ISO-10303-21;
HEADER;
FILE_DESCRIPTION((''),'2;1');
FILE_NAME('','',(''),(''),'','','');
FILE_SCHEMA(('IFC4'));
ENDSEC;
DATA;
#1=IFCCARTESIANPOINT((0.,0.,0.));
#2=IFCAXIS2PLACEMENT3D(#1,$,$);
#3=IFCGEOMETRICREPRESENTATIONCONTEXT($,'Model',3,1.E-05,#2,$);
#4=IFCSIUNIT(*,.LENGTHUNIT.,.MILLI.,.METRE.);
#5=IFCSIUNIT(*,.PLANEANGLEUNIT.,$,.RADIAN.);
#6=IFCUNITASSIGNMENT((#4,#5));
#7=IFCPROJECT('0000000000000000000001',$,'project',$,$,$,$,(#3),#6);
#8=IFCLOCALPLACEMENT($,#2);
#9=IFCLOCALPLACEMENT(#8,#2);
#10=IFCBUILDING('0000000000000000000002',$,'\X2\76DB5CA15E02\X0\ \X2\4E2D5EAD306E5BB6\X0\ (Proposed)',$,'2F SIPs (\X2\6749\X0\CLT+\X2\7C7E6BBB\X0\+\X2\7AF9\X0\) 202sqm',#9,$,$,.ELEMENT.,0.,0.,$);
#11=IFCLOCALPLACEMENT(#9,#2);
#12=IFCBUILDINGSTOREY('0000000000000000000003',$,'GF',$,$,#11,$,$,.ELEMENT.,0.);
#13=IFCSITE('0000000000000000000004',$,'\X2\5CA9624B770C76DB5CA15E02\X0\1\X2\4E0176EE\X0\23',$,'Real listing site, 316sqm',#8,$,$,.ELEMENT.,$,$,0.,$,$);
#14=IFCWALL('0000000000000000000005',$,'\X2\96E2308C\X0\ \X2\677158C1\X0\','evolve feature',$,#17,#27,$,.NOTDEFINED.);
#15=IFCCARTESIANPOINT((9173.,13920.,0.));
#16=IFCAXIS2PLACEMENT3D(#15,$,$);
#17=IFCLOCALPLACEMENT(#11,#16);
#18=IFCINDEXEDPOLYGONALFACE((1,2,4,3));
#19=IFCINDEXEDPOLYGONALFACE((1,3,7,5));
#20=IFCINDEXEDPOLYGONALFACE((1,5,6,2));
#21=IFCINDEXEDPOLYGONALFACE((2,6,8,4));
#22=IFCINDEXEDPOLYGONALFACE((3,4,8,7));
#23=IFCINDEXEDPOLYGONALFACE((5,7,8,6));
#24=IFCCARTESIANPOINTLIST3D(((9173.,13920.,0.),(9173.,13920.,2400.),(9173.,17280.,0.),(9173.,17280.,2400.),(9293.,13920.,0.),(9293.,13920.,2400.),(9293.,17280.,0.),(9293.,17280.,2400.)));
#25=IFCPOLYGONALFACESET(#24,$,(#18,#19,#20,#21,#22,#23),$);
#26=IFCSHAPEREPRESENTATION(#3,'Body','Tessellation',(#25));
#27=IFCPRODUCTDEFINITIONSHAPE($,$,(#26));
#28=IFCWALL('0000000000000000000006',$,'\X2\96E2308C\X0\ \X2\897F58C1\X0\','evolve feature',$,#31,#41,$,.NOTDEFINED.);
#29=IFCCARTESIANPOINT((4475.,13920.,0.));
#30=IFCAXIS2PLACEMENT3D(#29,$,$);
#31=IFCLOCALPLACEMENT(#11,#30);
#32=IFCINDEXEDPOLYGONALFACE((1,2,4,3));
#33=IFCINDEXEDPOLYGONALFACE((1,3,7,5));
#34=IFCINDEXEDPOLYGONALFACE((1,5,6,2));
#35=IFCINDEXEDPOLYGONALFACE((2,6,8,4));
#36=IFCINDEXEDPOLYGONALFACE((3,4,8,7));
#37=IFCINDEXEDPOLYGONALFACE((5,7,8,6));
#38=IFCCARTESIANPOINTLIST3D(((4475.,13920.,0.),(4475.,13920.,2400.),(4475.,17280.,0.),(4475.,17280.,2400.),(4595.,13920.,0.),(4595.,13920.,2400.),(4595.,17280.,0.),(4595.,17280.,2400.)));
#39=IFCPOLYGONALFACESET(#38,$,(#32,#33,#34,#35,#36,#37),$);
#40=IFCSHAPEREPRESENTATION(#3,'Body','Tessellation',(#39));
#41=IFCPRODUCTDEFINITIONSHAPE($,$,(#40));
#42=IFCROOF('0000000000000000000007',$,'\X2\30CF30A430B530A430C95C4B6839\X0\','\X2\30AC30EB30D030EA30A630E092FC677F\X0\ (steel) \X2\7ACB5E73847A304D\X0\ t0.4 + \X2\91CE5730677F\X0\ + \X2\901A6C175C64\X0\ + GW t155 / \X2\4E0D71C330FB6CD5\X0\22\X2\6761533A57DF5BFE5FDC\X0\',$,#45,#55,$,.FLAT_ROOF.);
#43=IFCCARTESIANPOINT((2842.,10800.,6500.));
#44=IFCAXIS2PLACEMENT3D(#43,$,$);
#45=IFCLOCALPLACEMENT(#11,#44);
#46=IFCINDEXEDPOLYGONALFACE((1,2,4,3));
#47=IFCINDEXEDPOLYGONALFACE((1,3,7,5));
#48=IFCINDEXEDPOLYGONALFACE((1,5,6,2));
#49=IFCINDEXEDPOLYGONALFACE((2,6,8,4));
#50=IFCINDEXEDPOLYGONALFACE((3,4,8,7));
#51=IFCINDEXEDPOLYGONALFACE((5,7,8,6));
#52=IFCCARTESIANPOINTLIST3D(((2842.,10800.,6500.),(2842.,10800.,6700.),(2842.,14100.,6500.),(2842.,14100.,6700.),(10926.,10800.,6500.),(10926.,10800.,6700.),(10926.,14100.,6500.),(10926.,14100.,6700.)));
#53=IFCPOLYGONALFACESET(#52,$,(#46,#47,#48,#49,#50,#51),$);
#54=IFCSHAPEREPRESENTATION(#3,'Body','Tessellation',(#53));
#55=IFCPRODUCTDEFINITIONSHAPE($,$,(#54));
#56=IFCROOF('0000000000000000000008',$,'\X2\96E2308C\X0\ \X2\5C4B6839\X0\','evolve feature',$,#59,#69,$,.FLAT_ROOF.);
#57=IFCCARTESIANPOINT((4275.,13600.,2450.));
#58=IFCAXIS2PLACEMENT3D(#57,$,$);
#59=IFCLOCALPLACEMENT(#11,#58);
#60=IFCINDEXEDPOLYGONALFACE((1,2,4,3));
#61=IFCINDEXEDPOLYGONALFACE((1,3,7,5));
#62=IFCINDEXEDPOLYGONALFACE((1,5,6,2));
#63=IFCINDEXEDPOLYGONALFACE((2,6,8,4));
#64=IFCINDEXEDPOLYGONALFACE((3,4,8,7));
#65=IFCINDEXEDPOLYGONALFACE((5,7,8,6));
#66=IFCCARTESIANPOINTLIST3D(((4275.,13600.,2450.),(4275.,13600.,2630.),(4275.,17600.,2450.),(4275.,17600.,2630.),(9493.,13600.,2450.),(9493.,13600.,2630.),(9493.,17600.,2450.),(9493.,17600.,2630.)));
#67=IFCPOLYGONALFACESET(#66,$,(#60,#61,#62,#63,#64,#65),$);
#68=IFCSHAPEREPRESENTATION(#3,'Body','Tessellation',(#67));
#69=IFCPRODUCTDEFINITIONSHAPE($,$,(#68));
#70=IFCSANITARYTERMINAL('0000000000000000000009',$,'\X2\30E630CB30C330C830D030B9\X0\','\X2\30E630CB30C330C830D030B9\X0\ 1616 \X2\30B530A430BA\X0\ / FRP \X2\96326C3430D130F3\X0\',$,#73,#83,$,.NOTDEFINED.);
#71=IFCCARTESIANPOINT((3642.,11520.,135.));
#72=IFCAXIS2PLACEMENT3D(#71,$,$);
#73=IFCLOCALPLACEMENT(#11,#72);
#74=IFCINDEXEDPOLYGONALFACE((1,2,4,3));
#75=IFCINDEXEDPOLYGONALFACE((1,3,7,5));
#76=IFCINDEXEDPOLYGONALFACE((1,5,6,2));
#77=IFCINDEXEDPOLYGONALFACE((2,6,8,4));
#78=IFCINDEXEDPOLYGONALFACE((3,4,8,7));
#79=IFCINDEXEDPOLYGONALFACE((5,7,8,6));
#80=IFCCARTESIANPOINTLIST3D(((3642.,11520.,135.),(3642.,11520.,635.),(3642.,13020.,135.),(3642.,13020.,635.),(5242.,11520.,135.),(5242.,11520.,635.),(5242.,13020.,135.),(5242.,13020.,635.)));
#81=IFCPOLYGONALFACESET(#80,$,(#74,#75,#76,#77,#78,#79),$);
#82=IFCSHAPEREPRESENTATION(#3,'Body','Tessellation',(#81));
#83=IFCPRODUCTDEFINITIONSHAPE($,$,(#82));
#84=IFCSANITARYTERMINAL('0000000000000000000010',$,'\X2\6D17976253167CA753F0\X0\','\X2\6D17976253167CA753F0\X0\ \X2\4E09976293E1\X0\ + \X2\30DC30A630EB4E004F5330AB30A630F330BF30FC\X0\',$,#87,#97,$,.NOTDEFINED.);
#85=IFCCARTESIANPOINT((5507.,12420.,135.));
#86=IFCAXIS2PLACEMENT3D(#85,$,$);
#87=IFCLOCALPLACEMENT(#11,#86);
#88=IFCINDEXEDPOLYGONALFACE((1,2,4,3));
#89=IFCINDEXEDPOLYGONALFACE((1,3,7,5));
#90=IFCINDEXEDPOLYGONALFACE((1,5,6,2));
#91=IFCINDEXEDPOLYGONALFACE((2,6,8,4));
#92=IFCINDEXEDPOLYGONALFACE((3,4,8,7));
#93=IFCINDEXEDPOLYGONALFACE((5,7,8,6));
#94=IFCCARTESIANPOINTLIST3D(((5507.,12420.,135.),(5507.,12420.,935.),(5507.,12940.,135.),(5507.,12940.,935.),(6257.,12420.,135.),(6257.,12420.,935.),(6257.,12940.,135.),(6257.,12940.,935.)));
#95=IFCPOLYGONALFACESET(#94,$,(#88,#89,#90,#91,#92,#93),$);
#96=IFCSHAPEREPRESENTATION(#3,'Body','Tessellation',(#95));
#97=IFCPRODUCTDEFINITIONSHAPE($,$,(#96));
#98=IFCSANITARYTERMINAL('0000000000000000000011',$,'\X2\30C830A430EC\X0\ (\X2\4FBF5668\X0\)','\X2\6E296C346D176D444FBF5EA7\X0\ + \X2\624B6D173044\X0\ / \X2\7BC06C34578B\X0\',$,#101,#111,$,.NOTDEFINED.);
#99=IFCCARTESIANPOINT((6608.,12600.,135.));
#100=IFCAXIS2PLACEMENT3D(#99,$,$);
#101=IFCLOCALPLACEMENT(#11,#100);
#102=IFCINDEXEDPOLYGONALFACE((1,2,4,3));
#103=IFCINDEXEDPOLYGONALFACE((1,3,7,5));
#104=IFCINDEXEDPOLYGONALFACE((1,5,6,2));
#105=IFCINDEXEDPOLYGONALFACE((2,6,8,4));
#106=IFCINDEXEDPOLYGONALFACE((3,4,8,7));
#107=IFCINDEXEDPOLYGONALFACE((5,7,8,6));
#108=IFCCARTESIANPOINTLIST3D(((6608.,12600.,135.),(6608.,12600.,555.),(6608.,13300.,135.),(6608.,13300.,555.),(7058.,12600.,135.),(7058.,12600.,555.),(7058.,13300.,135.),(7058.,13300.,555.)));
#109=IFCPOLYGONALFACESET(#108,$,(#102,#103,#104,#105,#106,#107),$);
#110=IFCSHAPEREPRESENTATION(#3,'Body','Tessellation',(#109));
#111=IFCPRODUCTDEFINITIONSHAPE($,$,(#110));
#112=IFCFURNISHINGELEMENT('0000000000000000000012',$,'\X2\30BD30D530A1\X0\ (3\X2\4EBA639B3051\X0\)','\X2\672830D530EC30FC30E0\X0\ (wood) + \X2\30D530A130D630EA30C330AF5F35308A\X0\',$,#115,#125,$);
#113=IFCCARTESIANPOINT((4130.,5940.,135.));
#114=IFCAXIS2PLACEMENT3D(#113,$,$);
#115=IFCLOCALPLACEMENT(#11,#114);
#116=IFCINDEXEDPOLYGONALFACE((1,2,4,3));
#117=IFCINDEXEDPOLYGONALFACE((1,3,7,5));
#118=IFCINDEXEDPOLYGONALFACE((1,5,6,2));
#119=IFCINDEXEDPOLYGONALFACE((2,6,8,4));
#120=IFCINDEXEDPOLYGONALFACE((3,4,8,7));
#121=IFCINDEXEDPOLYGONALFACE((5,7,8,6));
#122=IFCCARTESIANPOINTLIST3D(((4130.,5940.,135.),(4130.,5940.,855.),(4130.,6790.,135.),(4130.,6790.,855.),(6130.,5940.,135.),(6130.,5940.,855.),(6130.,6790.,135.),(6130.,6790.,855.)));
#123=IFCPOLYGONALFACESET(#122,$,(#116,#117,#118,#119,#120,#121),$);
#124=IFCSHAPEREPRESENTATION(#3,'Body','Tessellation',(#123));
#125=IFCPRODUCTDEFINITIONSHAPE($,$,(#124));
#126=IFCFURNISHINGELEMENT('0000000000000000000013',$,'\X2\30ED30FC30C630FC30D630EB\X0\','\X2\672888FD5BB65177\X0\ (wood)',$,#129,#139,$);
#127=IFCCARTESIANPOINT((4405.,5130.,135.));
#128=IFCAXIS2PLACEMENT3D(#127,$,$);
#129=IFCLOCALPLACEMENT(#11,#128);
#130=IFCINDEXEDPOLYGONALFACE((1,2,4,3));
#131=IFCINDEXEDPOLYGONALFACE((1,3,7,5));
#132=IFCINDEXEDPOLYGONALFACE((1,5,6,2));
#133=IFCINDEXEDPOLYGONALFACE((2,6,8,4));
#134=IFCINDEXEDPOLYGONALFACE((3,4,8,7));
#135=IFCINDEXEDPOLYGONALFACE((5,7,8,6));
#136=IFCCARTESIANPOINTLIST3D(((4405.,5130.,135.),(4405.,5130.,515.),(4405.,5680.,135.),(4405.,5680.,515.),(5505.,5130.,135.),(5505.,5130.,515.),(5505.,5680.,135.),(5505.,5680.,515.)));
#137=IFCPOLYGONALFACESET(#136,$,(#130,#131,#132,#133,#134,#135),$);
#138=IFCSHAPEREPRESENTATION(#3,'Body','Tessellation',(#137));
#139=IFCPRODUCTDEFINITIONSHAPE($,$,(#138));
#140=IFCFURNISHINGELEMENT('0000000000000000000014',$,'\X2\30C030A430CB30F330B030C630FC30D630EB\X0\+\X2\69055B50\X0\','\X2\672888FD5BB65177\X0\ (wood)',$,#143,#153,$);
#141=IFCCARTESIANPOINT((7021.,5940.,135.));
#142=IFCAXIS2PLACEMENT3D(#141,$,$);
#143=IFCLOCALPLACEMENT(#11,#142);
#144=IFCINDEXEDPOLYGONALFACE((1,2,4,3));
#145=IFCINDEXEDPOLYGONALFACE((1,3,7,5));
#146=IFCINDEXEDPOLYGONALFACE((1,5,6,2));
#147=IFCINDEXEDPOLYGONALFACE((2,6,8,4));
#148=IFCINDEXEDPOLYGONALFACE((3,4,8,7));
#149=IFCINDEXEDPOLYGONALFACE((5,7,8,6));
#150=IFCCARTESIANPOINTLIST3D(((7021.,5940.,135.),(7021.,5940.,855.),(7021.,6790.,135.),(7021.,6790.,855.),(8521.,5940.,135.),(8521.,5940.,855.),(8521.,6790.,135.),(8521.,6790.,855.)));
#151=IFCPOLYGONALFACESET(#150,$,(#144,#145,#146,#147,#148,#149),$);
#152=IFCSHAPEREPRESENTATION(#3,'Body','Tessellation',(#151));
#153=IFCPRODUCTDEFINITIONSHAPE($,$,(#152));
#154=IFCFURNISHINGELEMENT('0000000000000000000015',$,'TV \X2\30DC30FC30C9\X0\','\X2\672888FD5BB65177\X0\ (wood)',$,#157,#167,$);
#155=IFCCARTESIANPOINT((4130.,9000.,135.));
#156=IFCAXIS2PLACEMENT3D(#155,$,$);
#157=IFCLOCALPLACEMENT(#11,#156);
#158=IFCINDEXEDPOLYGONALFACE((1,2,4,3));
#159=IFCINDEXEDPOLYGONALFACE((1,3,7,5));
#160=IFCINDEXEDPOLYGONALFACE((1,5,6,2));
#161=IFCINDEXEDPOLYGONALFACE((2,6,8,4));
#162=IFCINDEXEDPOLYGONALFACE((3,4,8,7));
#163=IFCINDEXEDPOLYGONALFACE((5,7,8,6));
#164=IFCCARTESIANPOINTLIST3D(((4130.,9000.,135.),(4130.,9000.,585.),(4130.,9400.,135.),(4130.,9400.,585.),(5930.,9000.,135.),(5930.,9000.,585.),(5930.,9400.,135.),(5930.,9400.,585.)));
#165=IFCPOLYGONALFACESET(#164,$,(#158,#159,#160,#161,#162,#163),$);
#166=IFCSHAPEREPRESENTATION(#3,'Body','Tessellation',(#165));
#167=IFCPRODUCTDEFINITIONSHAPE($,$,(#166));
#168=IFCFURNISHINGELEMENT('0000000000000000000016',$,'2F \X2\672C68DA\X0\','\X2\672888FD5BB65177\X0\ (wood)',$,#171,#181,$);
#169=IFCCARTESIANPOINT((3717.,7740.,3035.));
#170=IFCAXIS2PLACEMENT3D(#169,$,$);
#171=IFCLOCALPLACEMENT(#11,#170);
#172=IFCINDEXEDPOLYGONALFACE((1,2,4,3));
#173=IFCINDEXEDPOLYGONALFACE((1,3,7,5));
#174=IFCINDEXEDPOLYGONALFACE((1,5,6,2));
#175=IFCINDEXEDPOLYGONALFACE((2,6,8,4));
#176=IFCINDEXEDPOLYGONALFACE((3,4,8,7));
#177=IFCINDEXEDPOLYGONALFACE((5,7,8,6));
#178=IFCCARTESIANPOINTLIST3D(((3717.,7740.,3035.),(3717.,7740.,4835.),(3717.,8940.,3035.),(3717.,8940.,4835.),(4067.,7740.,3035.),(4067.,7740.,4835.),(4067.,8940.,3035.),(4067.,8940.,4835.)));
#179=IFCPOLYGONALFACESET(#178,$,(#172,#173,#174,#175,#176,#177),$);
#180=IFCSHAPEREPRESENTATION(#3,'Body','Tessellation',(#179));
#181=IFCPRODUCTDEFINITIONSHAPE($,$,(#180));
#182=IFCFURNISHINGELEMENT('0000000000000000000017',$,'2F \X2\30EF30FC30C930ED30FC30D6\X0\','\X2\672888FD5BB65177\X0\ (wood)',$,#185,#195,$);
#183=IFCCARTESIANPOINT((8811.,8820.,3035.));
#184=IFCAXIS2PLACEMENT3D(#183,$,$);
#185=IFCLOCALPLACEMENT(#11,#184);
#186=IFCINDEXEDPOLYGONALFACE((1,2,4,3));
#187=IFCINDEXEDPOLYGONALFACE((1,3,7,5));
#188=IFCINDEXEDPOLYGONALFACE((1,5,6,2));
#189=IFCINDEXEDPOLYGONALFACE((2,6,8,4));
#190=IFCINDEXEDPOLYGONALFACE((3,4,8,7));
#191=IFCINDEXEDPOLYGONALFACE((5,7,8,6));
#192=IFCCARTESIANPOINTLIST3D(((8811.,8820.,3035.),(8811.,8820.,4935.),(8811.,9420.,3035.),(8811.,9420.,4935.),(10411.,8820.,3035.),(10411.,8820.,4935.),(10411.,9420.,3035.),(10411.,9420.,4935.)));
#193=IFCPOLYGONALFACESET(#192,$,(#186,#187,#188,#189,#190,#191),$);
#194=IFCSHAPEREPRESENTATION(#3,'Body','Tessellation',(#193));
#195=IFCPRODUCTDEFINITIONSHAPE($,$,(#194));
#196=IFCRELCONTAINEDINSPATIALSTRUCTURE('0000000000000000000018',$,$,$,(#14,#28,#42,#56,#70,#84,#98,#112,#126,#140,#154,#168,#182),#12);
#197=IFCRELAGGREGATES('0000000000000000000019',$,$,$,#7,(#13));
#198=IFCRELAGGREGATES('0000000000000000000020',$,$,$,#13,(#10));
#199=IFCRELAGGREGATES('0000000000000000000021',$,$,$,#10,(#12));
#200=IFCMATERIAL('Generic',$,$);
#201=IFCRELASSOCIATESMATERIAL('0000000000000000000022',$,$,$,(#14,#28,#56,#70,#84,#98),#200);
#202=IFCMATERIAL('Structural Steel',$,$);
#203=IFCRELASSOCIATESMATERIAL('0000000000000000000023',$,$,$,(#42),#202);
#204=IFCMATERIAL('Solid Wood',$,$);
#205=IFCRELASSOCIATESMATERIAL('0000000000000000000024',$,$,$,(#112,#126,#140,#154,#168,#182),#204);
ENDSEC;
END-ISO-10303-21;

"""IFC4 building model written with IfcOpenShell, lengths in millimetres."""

from ifc_helpers import new_model, si_unit, frame, frame_2d, origin, place, context, project, spatial, rectangle, extrude, material, element, save


model = new_model("IFC4")

# Units and contexts
model_context = context("Model", 3, precision=1e-05, world=origin())
ifc_project = project(units=[si_unit("LENGTHUNIT", "METRE", prefix="MILLI"), si_unit("PLANEANGLEUNIT", "RADIAN")], contexts=[model_context])

# Site, building, storey
site_placement = place(None, origin())
site = spatial("IfcSite", under=ifc_project, at=site_placement, Name="岩手県盛岡市1丁目23", ObjectType="Real listing site, 316sqm", CompositionType="ELEMENT", RefElevation=0.0)
building_placement = place(site_placement, origin())
building = spatial("IfcBuilding", under=site, at=building_placement, Name="盛岡市 中庭の家 (Proposed)", ObjectType="2F SIPs (杉CLT+籾殻+竹) 202sqm", CompositionType="ELEMENT", ElevationOfRefHeight=0.0, ElevationOfTerrain=0.0)
storey_placement = place(building_placement, origin())
storey = spatial("IfcBuildingStorey", under=building, at=storey_placement, Name="GF", CompositionType="ELEMENT", Elevation=0.0)

# Shared definitions
ifc_material_1 = material(Name="Generic")

# Shared definitions
ifc_material_2 = material(Name="Solid Wood")

# Walls
wall_1_placement = place(storey_placement, frame((9173.0, 13920.0, 0.0)))
element("IfcWall", 1, at=wall_1_placement, inside=storey, material=ifc_material_1, Name="離れ 東壁", Description="evolve feature", PredefinedType="NOTDEFINED", context=model_context, shape_type="SweptSolid", body=[
    extrude(rectangle(XDim=120.0, YDim=3360.0, at=frame_2d((60.0, 1680.0))), frame((9173.0, 13920.0, 0.0)), (0.0, 0.0, 1.0), 2400.0),
])
wall_2_placement = place(storey_placement, frame((4475.0, 13920.0, 0.0)))
element("IfcWall", 2, at=wall_2_placement, inside=storey, material=ifc_material_1, Name="離れ 西壁", Description="evolve feature", PredefinedType="NOTDEFINED", context=model_context, shape_type="SweptSolid", body=[
    extrude(rectangle(XDim=120.0, YDim=3360.0, at=frame_2d((60.0, 1680.0))), frame((4475.0, 13920.0, 0.0)), (0.0, 0.0, 1.0), 2400.0),
])

# Roofs
ifc_material_3 = material(Name="Structural Steel")
roof_1_placement = place(storey_placement, frame((2842.0, 10800.0, 6500.0)))
element("IfcRoof", 3, at=roof_1_placement, inside=storey, material=ifc_material_3, Name="ハイサイド屋根", Description="ガルバリウム鋼板 (steel) 立平葺き t0.4 + 野地板 + 通気層 + GW t155 / 不燃・法22条区域対応", PredefinedType="FLAT_ROOF", context=model_context, shape_type="SweptSolid", body=[
    extrude(rectangle(XDim=8084.0, YDim=3300.0, at=frame_2d((4042.0, 1650.0))), frame((2842.0, 10800.0, 6500.0)), (0.0, 0.0, 1.0), 200.0),
])
roof_2_placement = place(storey_placement, frame((4275.0, 13600.0, 2450.0)))
element("IfcRoof", 4, at=roof_2_placement, inside=storey, material=ifc_material_1, Name="離れ 屋根", Description="evolve feature", PredefinedType="FLAT_ROOF", context=model_context, shape_type="SweptSolid", body=[
    extrude(rectangle(XDim=5218.0, YDim=4000.0, at=frame_2d((2609.0, 2000.0))), frame((4275.0, 13600.0, 2450.0)), (0.0, 0.0, 1.0), 180.0),
])

# Sanitary terminals
sanitary_terminal_1_placement = place(storey_placement, frame((3642.0, 11520.0, 135.0)))
element("IfcSanitaryTerminal", 5, at=sanitary_terminal_1_placement, inside=storey, material=ifc_material_1, Name="ユニットバス", Description="ユニットバス 1616 サイズ / FRP 防水パン", PredefinedType="NOTDEFINED", context=model_context, shape_type="SweptSolid", body=[
    extrude(rectangle(XDim=1600.0, YDim=1500.0, at=frame_2d((800.0, 750.0))), frame((3642.0, 11520.0, 135.0)), (0.0, 0.0, 1.0), 500.0),
])
sanitary_terminal_2_placement = place(storey_placement, frame((5507.0, 12420.0, 135.0)))
element("IfcSanitaryTerminal", 6, at=sanitary_terminal_2_placement, inside=storey, material=ifc_material_1, Name="洗面化粧台", Description="洗面化粧台 三面鏡 + ボウル一体カウンター", PredefinedType="NOTDEFINED", context=model_context, shape_type="SweptSolid", body=[
    extrude(rectangle(XDim=750.0, YDim=520.0, at=frame_2d((375.0, 260.0))), frame((5507.0, 12420.0, 135.0)), (0.0, 0.0, 1.0), 800.0),
])
sanitary_terminal_3_placement = place(storey_placement, frame((6608.0, 12600.0, 135.0)))
element("IfcSanitaryTerminal", 7, at=sanitary_terminal_3_placement, inside=storey, material=ifc_material_1, Name="トイレ (便器)", Description="温水洗浄便座 + 手洗い / 節水型", PredefinedType="NOTDEFINED", context=model_context, shape_type="SweptSolid", body=[
    extrude(rectangle(XDim=450.0, YDim=700.0, at=frame_2d((225.0, 350.0))), frame((6608.0, 12600.0, 135.0)), (0.0, 0.0, 1.0), 420.0),
])

# Furnishing elements
furnishing_1_placement = place(storey_placement, frame((4130.0, 5940.0, 135.0)))
element("IfcFurnishingElement", 8, at=furnishing_1_placement, inside=storey, material=ifc_material_2, Name="ソファ (3人掛け)", Description="木フレーム (wood) + ファブリック張り", context=model_context, shape_type="SweptSolid", body=[
    extrude(rectangle(XDim=2000.0, YDim=850.0, at=frame_2d((1000.0, 425.0))), frame((4130.0, 5940.0, 135.0)), (0.0, 0.0, 1.0), 720.0),
])
furnishing_2_placement = place(storey_placement, frame((4405.0, 5130.0, 135.0)))
element("IfcFurnishingElement", 9, at=furnishing_2_placement, inside=storey, material=ifc_material_2, Name="ローテーブル", Description="木製家具 (wood)", context=model_context, shape_type="SweptSolid", body=[
    extrude(rectangle(XDim=1100.0, YDim=550.0, at=frame_2d((550.0, 275.0))), frame((4405.0, 5130.0, 135.0)), (0.0, 0.0, 1.0), 380.0),
])
furnishing_3_placement = place(storey_placement, frame((7021.0, 5940.0, 135.0)))
element("IfcFurnishingElement", 10, at=furnishing_3_placement, inside=storey, material=ifc_material_2, Name="ダイニングテーブル+椅子", Description="木製家具 (wood)", context=model_context, shape_type="SweptSolid", body=[
    extrude(rectangle(XDim=1500.0, YDim=850.0, at=frame_2d((750.0, 425.0))), frame((7021.0, 5940.0, 135.0)), (0.0, 0.0, 1.0), 720.0),
])
furnishing_4_placement = place(storey_placement, frame((4130.0, 9000.0, 135.0)))
element("IfcFurnishingElement", 11, at=furnishing_4_placement, inside=storey, material=ifc_material_2, Name="TV ボード", Description="木製家具 (wood)", context=model_context, shape_type="SweptSolid", body=[
    extrude(rectangle(XDim=1800.0, YDim=400.0, at=frame_2d((900.0, 200.0))), frame((4130.0, 9000.0, 135.0)), (0.0, 0.0, 1.0), 450.0),
])
furnishing_5_placement = place(storey_placement, frame((3717.0, 7740.0, 3035.0)))
element("IfcFurnishingElement", 12, at=furnishing_5_placement, inside=storey, material=ifc_material_2, Name="2F 本棚", Description="木製家具 (wood)", context=model_context, shape_type="SweptSolid", body=[
    extrude(rectangle(XDim=350.0, YDim=1200.0, at=frame_2d((175.0, 600.0))), frame((3717.0, 7740.0, 3035.0)), (0.0, 0.0, 1.0), 1800.0),
])
furnishing_6_placement = place(storey_placement, frame((8811.0, 8820.0, 3035.0)))
element("IfcFurnishingElement", 13, at=furnishing_6_placement, inside=storey, material=ifc_material_2, Name="2F ワードローブ", Description="木製家具 (wood)", context=model_context, shape_type="SweptSolid", body=[
    extrude(rectangle(XDim=1600.0, YDim=600.0, at=frame_2d((800.0, 300.0))), frame((8811.0, 8820.0, 3035.0)), (0.0, 0.0, 1.0), 1900.0),
])

save(model, "model.ifc")
